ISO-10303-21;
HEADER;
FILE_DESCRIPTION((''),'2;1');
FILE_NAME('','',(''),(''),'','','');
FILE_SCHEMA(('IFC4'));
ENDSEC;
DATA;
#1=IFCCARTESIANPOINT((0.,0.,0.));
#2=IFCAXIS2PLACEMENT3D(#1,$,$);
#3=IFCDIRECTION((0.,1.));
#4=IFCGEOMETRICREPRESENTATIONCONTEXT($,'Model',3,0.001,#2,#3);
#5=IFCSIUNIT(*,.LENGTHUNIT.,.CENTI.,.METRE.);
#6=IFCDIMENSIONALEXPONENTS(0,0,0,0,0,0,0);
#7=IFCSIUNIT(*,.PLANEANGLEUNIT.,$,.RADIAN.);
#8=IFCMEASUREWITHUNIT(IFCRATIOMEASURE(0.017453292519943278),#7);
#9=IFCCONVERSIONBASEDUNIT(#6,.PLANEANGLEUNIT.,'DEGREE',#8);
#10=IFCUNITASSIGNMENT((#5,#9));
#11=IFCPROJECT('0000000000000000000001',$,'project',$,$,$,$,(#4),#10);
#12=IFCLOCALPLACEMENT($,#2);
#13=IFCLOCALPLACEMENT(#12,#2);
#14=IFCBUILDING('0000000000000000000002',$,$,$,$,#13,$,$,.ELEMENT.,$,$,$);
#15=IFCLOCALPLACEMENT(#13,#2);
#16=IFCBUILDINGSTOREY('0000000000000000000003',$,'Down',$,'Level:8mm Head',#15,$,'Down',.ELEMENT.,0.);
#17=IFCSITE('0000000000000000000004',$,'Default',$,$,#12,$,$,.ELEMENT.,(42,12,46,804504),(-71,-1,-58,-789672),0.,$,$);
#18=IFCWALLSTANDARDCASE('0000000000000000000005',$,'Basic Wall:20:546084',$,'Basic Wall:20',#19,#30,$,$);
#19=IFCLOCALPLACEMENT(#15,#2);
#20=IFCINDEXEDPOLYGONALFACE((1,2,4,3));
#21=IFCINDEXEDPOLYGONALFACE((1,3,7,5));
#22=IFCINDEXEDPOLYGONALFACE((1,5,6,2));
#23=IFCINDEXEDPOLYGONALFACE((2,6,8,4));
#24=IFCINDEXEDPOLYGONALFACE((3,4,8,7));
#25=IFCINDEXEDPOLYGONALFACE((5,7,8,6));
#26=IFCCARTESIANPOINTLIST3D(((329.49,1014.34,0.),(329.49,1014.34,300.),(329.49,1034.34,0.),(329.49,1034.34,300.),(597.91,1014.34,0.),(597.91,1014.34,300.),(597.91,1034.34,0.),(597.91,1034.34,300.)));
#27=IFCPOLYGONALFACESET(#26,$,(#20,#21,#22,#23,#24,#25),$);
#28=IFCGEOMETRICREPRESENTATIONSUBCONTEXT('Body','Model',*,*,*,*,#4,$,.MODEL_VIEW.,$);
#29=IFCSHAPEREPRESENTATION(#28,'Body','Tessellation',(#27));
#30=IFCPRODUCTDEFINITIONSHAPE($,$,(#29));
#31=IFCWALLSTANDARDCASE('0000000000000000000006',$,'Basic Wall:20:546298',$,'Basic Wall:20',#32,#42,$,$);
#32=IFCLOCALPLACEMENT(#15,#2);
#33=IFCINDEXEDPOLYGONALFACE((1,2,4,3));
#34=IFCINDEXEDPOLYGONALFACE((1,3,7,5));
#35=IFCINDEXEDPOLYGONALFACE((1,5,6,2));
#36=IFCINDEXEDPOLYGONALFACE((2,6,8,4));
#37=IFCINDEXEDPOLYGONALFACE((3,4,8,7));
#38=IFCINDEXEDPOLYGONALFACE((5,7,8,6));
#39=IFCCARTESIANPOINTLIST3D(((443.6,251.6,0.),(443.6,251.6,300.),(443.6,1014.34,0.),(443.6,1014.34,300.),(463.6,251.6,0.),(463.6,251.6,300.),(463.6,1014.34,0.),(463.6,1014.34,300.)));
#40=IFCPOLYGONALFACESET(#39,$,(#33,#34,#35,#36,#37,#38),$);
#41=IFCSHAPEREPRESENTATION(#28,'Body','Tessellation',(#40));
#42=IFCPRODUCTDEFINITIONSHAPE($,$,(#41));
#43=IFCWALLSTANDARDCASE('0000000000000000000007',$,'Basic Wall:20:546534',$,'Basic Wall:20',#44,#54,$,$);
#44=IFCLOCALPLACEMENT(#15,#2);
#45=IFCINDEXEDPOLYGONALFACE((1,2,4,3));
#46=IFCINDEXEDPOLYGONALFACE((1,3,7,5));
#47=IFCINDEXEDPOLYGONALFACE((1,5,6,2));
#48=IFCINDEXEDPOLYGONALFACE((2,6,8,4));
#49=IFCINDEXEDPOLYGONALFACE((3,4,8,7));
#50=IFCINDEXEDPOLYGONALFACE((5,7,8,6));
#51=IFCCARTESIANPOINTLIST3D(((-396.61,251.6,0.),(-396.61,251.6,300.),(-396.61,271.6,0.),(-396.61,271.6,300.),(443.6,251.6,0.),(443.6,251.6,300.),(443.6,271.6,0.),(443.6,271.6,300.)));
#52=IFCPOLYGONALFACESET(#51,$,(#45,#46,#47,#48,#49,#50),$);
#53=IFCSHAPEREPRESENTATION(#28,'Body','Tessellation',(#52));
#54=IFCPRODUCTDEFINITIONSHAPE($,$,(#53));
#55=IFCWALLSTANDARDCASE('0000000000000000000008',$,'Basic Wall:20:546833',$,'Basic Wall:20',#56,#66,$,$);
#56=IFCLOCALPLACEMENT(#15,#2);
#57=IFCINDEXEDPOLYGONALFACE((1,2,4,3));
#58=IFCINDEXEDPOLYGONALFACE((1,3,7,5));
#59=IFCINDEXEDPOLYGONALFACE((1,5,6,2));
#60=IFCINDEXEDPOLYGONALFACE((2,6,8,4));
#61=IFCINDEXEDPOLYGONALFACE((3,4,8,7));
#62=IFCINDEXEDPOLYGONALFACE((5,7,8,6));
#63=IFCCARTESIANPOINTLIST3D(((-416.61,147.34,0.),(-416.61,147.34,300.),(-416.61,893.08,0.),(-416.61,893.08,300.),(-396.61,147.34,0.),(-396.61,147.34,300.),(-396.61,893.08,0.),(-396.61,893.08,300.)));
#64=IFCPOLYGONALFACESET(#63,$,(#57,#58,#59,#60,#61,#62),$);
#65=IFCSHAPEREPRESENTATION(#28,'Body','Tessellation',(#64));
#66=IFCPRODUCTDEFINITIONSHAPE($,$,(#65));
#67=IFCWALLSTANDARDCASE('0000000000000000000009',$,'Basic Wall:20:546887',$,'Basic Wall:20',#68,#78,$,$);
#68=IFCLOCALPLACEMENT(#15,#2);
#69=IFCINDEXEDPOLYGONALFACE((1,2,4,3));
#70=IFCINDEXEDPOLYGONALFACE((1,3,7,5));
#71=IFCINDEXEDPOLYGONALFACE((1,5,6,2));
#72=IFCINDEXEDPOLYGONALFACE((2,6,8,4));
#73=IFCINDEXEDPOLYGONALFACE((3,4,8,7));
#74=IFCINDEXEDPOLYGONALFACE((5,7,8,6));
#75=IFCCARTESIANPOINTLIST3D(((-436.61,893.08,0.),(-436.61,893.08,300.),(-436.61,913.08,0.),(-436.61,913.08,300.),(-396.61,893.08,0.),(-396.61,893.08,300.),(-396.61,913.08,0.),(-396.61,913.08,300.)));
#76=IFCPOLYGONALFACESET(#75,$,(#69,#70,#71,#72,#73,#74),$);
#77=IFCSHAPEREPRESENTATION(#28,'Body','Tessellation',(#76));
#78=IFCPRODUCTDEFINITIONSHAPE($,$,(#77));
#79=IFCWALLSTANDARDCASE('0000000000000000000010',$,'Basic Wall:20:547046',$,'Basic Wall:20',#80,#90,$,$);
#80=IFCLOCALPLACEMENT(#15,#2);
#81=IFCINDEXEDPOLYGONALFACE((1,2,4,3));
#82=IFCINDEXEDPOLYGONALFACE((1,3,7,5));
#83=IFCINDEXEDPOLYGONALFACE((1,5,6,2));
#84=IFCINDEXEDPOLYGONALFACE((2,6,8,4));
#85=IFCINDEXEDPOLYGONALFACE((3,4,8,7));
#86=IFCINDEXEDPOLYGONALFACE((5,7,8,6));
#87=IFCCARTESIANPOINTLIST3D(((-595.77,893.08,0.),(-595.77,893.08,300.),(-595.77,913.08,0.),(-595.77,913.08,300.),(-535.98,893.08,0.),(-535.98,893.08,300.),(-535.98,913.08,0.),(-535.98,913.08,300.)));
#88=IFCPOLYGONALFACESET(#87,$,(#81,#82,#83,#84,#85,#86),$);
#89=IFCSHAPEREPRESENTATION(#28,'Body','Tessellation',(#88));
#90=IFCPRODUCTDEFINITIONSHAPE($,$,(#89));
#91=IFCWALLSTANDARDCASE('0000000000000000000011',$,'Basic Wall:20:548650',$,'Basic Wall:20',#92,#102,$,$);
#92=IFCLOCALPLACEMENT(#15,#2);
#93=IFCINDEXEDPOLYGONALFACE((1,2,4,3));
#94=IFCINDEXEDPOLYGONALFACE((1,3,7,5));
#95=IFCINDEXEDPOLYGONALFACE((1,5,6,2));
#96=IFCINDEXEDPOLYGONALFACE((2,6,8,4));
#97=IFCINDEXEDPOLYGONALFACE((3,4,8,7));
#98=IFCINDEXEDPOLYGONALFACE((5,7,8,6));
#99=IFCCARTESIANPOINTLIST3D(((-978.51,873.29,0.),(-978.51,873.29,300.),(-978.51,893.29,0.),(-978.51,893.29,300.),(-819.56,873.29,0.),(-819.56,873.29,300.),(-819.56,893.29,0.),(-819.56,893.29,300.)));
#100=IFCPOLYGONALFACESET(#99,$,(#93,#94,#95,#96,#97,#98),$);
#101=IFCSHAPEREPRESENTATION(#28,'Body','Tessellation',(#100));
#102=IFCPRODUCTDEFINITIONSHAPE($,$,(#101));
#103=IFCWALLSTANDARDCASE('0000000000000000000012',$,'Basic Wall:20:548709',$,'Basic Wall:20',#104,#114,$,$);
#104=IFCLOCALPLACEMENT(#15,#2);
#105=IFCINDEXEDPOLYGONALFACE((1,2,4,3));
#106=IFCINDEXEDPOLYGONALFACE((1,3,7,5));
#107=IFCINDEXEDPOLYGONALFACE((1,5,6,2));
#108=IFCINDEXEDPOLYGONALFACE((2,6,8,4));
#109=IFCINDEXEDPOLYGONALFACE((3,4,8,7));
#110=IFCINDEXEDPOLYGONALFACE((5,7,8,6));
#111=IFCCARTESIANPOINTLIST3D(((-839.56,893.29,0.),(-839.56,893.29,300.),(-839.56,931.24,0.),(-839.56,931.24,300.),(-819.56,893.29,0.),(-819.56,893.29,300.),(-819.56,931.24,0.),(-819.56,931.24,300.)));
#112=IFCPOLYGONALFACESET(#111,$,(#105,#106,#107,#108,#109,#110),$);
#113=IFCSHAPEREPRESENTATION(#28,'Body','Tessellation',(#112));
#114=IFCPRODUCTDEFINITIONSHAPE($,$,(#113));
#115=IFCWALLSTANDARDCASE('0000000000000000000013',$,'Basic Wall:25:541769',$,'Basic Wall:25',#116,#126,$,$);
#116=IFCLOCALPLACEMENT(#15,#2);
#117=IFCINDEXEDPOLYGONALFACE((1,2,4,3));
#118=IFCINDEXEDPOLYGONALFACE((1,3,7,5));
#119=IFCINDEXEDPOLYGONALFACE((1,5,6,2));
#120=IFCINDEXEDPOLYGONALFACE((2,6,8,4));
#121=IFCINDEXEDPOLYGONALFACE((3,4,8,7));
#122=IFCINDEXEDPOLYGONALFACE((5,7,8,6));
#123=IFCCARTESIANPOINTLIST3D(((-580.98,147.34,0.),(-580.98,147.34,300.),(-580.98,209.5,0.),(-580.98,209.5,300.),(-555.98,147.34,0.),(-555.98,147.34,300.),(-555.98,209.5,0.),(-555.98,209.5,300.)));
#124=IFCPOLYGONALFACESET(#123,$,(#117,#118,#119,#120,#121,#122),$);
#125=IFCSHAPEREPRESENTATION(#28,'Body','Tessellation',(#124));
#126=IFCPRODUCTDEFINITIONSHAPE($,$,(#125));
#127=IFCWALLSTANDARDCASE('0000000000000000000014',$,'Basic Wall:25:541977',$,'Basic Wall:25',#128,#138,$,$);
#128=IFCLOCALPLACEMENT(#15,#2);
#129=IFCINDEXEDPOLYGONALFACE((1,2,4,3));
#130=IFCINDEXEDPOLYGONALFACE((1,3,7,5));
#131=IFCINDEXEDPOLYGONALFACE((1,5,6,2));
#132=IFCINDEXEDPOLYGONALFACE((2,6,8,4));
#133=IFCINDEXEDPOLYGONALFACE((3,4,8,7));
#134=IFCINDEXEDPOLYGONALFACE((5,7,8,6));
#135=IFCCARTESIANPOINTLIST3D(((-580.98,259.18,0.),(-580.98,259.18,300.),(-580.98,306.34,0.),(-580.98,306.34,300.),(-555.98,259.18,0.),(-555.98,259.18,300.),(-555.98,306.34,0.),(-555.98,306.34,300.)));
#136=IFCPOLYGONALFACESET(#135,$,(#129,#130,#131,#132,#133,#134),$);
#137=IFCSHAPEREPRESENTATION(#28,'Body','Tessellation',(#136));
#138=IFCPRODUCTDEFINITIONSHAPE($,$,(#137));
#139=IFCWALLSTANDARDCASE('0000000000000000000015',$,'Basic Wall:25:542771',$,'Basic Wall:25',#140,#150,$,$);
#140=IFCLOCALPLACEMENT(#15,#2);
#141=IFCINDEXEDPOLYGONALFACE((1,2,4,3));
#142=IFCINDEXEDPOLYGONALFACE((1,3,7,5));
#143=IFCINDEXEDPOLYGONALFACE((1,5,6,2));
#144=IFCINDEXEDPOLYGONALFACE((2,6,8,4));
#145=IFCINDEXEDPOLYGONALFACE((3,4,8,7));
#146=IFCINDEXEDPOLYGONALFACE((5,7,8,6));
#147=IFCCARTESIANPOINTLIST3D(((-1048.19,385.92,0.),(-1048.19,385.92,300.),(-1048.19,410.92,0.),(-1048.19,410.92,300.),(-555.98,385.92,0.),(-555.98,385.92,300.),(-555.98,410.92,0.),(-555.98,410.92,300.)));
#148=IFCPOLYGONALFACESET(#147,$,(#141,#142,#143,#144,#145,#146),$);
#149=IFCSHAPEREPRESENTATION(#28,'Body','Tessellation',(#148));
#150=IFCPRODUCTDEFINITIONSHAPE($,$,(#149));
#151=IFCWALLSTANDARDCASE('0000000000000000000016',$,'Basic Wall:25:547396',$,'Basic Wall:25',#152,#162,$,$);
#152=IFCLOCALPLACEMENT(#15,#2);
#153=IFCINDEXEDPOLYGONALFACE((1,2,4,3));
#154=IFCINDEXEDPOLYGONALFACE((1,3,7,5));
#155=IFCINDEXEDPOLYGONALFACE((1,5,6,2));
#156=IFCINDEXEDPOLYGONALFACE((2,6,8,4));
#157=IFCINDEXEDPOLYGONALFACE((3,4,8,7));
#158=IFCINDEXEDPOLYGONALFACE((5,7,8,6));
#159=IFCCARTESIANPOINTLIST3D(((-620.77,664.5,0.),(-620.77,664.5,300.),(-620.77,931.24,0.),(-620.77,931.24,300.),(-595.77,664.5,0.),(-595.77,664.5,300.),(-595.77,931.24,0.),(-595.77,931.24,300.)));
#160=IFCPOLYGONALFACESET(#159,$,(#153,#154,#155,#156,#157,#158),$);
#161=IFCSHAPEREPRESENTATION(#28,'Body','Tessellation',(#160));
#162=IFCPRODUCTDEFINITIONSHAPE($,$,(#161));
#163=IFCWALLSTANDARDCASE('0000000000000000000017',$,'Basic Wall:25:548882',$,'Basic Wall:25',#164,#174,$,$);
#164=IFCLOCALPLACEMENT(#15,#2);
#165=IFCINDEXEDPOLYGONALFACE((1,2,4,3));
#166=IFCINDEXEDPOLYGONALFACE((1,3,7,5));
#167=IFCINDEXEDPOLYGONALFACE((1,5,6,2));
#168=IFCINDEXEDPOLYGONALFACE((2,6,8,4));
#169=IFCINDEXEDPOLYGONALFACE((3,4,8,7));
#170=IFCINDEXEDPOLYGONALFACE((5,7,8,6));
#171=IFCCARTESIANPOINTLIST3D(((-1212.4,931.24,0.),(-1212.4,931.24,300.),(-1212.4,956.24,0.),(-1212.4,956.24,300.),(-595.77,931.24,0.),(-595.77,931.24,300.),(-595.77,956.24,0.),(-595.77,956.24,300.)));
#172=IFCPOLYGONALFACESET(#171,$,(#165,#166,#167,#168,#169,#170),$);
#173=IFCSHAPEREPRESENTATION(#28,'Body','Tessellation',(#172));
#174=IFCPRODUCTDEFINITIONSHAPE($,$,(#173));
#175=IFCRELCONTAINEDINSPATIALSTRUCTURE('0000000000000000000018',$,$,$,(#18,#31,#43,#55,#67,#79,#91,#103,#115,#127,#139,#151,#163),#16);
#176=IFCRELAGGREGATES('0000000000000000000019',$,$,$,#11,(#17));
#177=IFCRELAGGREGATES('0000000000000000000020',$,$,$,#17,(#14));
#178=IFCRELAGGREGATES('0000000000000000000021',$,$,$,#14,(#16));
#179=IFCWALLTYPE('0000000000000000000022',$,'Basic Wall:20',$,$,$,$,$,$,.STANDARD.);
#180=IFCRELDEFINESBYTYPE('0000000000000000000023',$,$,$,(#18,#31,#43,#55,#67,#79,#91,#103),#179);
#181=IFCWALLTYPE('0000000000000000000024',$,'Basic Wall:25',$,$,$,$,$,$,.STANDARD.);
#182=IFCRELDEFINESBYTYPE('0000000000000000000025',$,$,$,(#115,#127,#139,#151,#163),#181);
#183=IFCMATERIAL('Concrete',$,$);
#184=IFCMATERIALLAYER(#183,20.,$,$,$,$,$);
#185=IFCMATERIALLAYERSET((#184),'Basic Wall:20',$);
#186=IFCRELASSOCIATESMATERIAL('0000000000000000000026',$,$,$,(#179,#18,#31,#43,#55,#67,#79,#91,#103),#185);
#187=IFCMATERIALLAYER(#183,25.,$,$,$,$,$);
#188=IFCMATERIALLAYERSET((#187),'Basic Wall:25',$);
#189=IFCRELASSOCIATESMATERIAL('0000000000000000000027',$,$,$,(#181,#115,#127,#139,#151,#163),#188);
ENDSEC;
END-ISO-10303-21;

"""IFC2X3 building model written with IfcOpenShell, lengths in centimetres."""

from ifc_helpers import new_model, entity, si_unit, converted_unit, direction, frame, frame_2d, origin, place, context, subcontext, project, spatial, rectangle, extrude, material, layer, layer_set, layer_usage, type_object, element, save


model = new_model("IFC2X3")

# Units and contexts
model_context = context("Model", 3, precision=0.001, world=origin(), true_north=direction((0.0, 1.0)))
body_context = subcontext(model_context, "Body", "Model", "MODEL_VIEW")
ifc_project = project(units=[si_unit("LENGTHUNIT", "METRE", prefix="CENTI"), converted_unit("PLANEANGLEUNIT", "DEGREE", entity("IfcRatioMeasure", 0.017453292519943278), si_unit("PLANEANGLEUNIT", "RADIAN"), dimensions=[0, 0, 0, 0, 0, 0, 0])], contexts=[model_context])

# Site, building, storey
site_placement = place(None, origin())
site = spatial("IfcSite", under=ifc_project, at=site_placement, Name="Default", CompositionType="ELEMENT", RefLatitude=(42, 12, 46, 804504), RefLongitude=(-71, -1, -58, -789672), RefElevation=0.0)
building_placement = place(site_placement, origin())
building = spatial("IfcBuilding", under=site, at=building_placement, CompositionType="ELEMENT")
storey_placement = place(building_placement, origin())
storey = spatial("IfcBuildingStorey", under=building, at=storey_placement, Name="Down", ObjectType="Level:8mm Head", LongName="Down", CompositionType="ELEMENT", Elevation=0.0)

# Shared definitions
ifc_material = material(Name="Concrete")

# Walls
ifc_layer_1 = layer(ifc_material, 20.0)
ifc_layer_set_1 = layer_set([ifc_layer_1], Name="Basic Wall:20")
wall_type_1 = type_object("IfcWallType", Name="Basic Wall:20", PredefinedType="STANDARD", material=ifc_layer_set_1)
ifc_layer_usage_1 = layer_usage(ifc_layer_set_1, "AXIS2", "NEGATIVE", 10.0)
wall_1_placement = place(storey_placement, frame((329.49, 1024.34, 0.0)))
element("IfcWallStandardCase", 1, at=wall_1_placement, inside=storey, type_object=wall_type_1, material=ifc_layer_usage_1, Name="Basic Wall:20:546084", ObjectType="Basic Wall:20", context=body_context, shape_type="SweptSolid", body=[
    extrude(rectangle(XDim=268.42, YDim=20.0, at=frame_2d((134.21, 0.0), x_axis=(-1.0, 0.0))), origin(), (0.0, 0.0, 1.0), 300.0),
])
ifc_layer_usage_2 = layer_usage(ifc_layer_set_1, "AXIS2", "NEGATIVE", 10.0)
wall_2_placement = place(storey_placement, frame((453.6, 1014.34, 0.0), z_axis=(0.0, 0.0, 1.0), x_axis=(0.0, -1.0, 0.0)))
element("IfcWallStandardCase", 2, at=wall_2_placement, inside=storey, type_object=wall_type_1, material=ifc_layer_usage_2, Name="Basic Wall:20:546298", ObjectType="Basic Wall:20", context=body_context, shape_type="SweptSolid", body=[
    extrude(rectangle(XDim=762.74, YDim=20.0, at=frame_2d((381.37, 0.0), x_axis=(-1.0, 0.0))), origin(), (0.0, 0.0, 1.0), 300.0),
])
ifc_layer_usage_3 = layer_usage(ifc_layer_set_1, "AXIS2", "NEGATIVE", 10.0)
wall_3_placement = place(storey_placement, frame((443.6, 261.6, 0.0), z_axis=(0.0, 0.0, 1.0), x_axis=(-1.0, 0.0, 0.0)))
element("IfcWallStandardCase", 3, at=wall_3_placement, inside=storey, type_object=wall_type_1, material=ifc_layer_usage_3, Name="Basic Wall:20:546534", ObjectType="Basic Wall:20", context=body_context, shape_type="SweptSolid", body=[
    extrude(rectangle(XDim=840.21, YDim=20.0, at=frame_2d((420.11, 0.0), x_axis=(-1.0, 0.0))), origin(), (0.0, 0.0, 1.0), 300.0),
])
ifc_layer_usage_4 = layer_usage(ifc_layer_set_1, "AXIS2", "NEGATIVE", 10.0)
wall_4_placement = place(storey_placement, frame((-406.61, 147.34, 0.0), z_axis=(0.0, 0.0, 1.0), x_axis=(0.0, 1.0, 0.0)))
element("IfcWallStandardCase", 4, at=wall_4_placement, inside=storey, type_object=wall_type_1, material=ifc_layer_usage_4, Name="Basic Wall:20:546833", ObjectType="Basic Wall:20", context=body_context, shape_type="SweptSolid", body=[
    extrude(rectangle(XDim=745.74, YDim=20.0, at=frame_2d((372.87, 0.0), x_axis=(-1.0, 0.0))), origin(), (0.0, 0.0, 1.0), 300.0),
])
ifc_layer_usage_5 = layer_usage(ifc_layer_set_1, "AXIS2", "POSITIVE", -10.0)
wall_5_placement = place(storey_placement, frame((-396.61, 903.08, 0.0), z_axis=(0.0, 0.0, 1.0), x_axis=(-1.0, 0.0, 0.0)))
element("IfcWallStandardCase", 5, at=wall_5_placement, inside=storey, type_object=wall_type_1, material=ifc_layer_usage_5, Name="Basic Wall:20:546887", ObjectType="Basic Wall:20", context=body_context, shape_type="SweptSolid", body=[
    extrude(rectangle(XDim=40.0, YDim=20.0, at=frame_2d((20.0, 0.0), x_axis=(-1.0, 0.0))), origin(), (0.0, 0.0, 1.0), 300.0),
])
ifc_layer_usage_6 = layer_usage(ifc_layer_set_1, "AXIS2", "POSITIVE", -10.0)
wall_6_placement = place(storey_placement, frame((-535.98, 903.08, 0.0), z_axis=(0.0, 0.0, 1.0), x_axis=(-1.0, 0.0, 0.0)))
element("IfcWallStandardCase", 6, at=wall_6_placement, inside=storey, type_object=wall_type_1, material=ifc_layer_usage_6, Name="Basic Wall:20:547046", ObjectType="Basic Wall:20", context=body_context, shape_type="SweptSolid", body=[
    extrude(rectangle(XDim=59.79, YDim=20.0, at=frame_2d((29.89, 0.0), x_axis=(-1.0, 0.0))), origin(), (0.0, 0.0, 1.0), 300.0),
])
ifc_layer_usage_7 = layer_usage(ifc_layer_set_1, "AXIS2", "POSITIVE", -10.0)
wall_7_placement = place(storey_placement, frame((-978.51, 883.29, 0.0)))
element("IfcWallStandardCase", 7, at=wall_7_placement, inside=storey, type_object=wall_type_1, material=ifc_layer_usage_7, Name="Basic Wall:20:548650", ObjectType="Basic Wall:20", context=body_context, shape_type="SweptSolid", body=[
    extrude(rectangle(XDim=158.95, YDim=20.0, at=frame_2d((79.47, 0.0), x_axis=(-1.0, 0.0))), origin(), (0.0, 0.0, 1.0), 300.0),
])
ifc_layer_usage_8 = layer_usage(ifc_layer_set_1, "AXIS2", "POSITIVE", -10.0)
wall_8_placement = place(storey_placement, frame((-829.56, 893.29, 0.0), z_axis=(0.0, 0.0, 1.0), x_axis=(0.0, 1.0, 0.0)))
element("IfcWallStandardCase", 8, at=wall_8_placement, inside=storey, type_object=wall_type_1, material=ifc_layer_usage_8, Name="Basic Wall:20:548709", ObjectType="Basic Wall:20", context=body_context, shape_type="SweptSolid", body=[
    extrude(rectangle(XDim=37.95, YDim=20.0, at=frame_2d((18.97, 0.0), x_axis=(-1.0, 0.0))), origin(), (0.0, 0.0, 1.0), 300.0),
])
ifc_layer_2 = layer(ifc_material, 25.0)
ifc_layer_set_2 = layer_set([ifc_layer_2], Name="Basic Wall:25")
ifc_layer_usage_9 = layer_usage(ifc_layer_set_2, "AXIS2", "POSITIVE", -12.5)
wall_type_2 = type_object("IfcWallType", Name="Basic Wall:25", PredefinedType="STANDARD", material=ifc_layer_set_2)
wall_9_placement = place(storey_placement, frame((-568.48, 147.34, 0.0), z_axis=(0.0, 0.0, 1.0), x_axis=(0.0, 1.0, 0.0)))
element("IfcWallStandardCase", 9, at=wall_9_placement, inside=storey, type_object=wall_type_2, material=ifc_layer_usage_9, Name="Basic Wall:25:541769", ObjectType="Basic Wall:25", context=body_context, shape_type="SweptSolid", body=[
    extrude(rectangle(XDim=62.16, YDim=25.0, at=frame_2d((31.08, 0.0), x_axis=(-1.0, 0.0))), origin(), (0.0, 0.0, 1.0), 300.0),
])
ifc_layer_usage_10 = layer_usage(ifc_layer_set_2, "AXIS2", "POSITIVE", -12.5)
wall_10_placement = place(storey_placement, frame((-568.48, 259.18, 0.0), z_axis=(0.0, 0.0, 1.0), x_axis=(0.0, 1.0, 0.0)))
element("IfcWallStandardCase", 10, at=wall_10_placement, inside=storey, type_object=wall_type_2, material=ifc_layer_usage_10, Name="Basic Wall:25:541977", ObjectType="Basic Wall:25", context=body_context, shape_type="SweptSolid", body=[
    extrude(rectangle(XDim=47.16, YDim=25.0, at=frame_2d((23.58, 0.0), x_axis=(-1.0, 0.0))), origin(), (0.0, 0.0, 1.0), 300.0),
])
ifc_layer_usage_11 = layer_usage(ifc_layer_set_2, "AXIS2", "NEGATIVE", 12.5)
wall_11_placement = place(storey_placement, frame((-555.98, 398.42, 0.0), z_axis=(0.0, 0.0, 1.0), x_axis=(-1.0, 0.0, 0.0)))
element("IfcWallStandardCase", 11, at=wall_11_placement, inside=storey, type_object=wall_type_2, material=ifc_layer_usage_11, Name="Basic Wall:25:542771", ObjectType="Basic Wall:25", context=body_context, shape_type="SweptSolid", body=[
    extrude(rectangle(XDim=492.21, YDim=25.0, at=frame_2d((246.11, 0.0), x_axis=(-1.0, 0.0))), origin(), (0.0, 0.0, 1.0), 300.0),
])
ifc_layer_usage_12 = layer_usage(ifc_layer_set_2, "AXIS2", "POSITIVE", -12.5)
wall_12_placement = place(storey_placement, frame((-608.27, 931.24, 0.0), z_axis=(0.0, 0.0, 1.0), x_axis=(0.0, -1.0, 0.0)))
element("IfcWallStandardCase", 12, at=wall_12_placement, inside=storey, type_object=wall_type_2, material=ifc_layer_usage_12, Name="Basic Wall:25:547396", ObjectType="Basic Wall:25", context=body_context, shape_type="SweptSolid", body=[
    extrude(rectangle(XDim=266.74, YDim=25.0, at=frame_2d((133.37, 0.0), x_axis=(-1.0, 0.0))), origin(), (0.0, 0.0, 1.0), 300.0),
])
ifc_layer_usage_13 = layer_usage(ifc_layer_set_2, "AXIS2", "POSITIVE", -12.5)
wall_13_placement = place(storey_placement, frame((-595.77, 943.74, 0.0), z_axis=(0.0, 0.0, 1.0), x_axis=(-1.0, 0.0, 0.0)))
element("IfcWallStandardCase", 13, at=wall_13_placement, inside=storey, type_object=wall_type_2, material=ifc_layer_usage_13, Name="Basic Wall:25:548882", ObjectType="Basic Wall:25", context=body_context, shape_type="SweptSolid", body=[
    extrude(rectangle(XDim=616.63, YDim=25.0, at=frame_2d((308.32, 0.0), x_axis=(-1.0, 0.0))), origin(), (0.0, 0.0, 1.0), 300.0),
])

save(model, "model.ifc")
